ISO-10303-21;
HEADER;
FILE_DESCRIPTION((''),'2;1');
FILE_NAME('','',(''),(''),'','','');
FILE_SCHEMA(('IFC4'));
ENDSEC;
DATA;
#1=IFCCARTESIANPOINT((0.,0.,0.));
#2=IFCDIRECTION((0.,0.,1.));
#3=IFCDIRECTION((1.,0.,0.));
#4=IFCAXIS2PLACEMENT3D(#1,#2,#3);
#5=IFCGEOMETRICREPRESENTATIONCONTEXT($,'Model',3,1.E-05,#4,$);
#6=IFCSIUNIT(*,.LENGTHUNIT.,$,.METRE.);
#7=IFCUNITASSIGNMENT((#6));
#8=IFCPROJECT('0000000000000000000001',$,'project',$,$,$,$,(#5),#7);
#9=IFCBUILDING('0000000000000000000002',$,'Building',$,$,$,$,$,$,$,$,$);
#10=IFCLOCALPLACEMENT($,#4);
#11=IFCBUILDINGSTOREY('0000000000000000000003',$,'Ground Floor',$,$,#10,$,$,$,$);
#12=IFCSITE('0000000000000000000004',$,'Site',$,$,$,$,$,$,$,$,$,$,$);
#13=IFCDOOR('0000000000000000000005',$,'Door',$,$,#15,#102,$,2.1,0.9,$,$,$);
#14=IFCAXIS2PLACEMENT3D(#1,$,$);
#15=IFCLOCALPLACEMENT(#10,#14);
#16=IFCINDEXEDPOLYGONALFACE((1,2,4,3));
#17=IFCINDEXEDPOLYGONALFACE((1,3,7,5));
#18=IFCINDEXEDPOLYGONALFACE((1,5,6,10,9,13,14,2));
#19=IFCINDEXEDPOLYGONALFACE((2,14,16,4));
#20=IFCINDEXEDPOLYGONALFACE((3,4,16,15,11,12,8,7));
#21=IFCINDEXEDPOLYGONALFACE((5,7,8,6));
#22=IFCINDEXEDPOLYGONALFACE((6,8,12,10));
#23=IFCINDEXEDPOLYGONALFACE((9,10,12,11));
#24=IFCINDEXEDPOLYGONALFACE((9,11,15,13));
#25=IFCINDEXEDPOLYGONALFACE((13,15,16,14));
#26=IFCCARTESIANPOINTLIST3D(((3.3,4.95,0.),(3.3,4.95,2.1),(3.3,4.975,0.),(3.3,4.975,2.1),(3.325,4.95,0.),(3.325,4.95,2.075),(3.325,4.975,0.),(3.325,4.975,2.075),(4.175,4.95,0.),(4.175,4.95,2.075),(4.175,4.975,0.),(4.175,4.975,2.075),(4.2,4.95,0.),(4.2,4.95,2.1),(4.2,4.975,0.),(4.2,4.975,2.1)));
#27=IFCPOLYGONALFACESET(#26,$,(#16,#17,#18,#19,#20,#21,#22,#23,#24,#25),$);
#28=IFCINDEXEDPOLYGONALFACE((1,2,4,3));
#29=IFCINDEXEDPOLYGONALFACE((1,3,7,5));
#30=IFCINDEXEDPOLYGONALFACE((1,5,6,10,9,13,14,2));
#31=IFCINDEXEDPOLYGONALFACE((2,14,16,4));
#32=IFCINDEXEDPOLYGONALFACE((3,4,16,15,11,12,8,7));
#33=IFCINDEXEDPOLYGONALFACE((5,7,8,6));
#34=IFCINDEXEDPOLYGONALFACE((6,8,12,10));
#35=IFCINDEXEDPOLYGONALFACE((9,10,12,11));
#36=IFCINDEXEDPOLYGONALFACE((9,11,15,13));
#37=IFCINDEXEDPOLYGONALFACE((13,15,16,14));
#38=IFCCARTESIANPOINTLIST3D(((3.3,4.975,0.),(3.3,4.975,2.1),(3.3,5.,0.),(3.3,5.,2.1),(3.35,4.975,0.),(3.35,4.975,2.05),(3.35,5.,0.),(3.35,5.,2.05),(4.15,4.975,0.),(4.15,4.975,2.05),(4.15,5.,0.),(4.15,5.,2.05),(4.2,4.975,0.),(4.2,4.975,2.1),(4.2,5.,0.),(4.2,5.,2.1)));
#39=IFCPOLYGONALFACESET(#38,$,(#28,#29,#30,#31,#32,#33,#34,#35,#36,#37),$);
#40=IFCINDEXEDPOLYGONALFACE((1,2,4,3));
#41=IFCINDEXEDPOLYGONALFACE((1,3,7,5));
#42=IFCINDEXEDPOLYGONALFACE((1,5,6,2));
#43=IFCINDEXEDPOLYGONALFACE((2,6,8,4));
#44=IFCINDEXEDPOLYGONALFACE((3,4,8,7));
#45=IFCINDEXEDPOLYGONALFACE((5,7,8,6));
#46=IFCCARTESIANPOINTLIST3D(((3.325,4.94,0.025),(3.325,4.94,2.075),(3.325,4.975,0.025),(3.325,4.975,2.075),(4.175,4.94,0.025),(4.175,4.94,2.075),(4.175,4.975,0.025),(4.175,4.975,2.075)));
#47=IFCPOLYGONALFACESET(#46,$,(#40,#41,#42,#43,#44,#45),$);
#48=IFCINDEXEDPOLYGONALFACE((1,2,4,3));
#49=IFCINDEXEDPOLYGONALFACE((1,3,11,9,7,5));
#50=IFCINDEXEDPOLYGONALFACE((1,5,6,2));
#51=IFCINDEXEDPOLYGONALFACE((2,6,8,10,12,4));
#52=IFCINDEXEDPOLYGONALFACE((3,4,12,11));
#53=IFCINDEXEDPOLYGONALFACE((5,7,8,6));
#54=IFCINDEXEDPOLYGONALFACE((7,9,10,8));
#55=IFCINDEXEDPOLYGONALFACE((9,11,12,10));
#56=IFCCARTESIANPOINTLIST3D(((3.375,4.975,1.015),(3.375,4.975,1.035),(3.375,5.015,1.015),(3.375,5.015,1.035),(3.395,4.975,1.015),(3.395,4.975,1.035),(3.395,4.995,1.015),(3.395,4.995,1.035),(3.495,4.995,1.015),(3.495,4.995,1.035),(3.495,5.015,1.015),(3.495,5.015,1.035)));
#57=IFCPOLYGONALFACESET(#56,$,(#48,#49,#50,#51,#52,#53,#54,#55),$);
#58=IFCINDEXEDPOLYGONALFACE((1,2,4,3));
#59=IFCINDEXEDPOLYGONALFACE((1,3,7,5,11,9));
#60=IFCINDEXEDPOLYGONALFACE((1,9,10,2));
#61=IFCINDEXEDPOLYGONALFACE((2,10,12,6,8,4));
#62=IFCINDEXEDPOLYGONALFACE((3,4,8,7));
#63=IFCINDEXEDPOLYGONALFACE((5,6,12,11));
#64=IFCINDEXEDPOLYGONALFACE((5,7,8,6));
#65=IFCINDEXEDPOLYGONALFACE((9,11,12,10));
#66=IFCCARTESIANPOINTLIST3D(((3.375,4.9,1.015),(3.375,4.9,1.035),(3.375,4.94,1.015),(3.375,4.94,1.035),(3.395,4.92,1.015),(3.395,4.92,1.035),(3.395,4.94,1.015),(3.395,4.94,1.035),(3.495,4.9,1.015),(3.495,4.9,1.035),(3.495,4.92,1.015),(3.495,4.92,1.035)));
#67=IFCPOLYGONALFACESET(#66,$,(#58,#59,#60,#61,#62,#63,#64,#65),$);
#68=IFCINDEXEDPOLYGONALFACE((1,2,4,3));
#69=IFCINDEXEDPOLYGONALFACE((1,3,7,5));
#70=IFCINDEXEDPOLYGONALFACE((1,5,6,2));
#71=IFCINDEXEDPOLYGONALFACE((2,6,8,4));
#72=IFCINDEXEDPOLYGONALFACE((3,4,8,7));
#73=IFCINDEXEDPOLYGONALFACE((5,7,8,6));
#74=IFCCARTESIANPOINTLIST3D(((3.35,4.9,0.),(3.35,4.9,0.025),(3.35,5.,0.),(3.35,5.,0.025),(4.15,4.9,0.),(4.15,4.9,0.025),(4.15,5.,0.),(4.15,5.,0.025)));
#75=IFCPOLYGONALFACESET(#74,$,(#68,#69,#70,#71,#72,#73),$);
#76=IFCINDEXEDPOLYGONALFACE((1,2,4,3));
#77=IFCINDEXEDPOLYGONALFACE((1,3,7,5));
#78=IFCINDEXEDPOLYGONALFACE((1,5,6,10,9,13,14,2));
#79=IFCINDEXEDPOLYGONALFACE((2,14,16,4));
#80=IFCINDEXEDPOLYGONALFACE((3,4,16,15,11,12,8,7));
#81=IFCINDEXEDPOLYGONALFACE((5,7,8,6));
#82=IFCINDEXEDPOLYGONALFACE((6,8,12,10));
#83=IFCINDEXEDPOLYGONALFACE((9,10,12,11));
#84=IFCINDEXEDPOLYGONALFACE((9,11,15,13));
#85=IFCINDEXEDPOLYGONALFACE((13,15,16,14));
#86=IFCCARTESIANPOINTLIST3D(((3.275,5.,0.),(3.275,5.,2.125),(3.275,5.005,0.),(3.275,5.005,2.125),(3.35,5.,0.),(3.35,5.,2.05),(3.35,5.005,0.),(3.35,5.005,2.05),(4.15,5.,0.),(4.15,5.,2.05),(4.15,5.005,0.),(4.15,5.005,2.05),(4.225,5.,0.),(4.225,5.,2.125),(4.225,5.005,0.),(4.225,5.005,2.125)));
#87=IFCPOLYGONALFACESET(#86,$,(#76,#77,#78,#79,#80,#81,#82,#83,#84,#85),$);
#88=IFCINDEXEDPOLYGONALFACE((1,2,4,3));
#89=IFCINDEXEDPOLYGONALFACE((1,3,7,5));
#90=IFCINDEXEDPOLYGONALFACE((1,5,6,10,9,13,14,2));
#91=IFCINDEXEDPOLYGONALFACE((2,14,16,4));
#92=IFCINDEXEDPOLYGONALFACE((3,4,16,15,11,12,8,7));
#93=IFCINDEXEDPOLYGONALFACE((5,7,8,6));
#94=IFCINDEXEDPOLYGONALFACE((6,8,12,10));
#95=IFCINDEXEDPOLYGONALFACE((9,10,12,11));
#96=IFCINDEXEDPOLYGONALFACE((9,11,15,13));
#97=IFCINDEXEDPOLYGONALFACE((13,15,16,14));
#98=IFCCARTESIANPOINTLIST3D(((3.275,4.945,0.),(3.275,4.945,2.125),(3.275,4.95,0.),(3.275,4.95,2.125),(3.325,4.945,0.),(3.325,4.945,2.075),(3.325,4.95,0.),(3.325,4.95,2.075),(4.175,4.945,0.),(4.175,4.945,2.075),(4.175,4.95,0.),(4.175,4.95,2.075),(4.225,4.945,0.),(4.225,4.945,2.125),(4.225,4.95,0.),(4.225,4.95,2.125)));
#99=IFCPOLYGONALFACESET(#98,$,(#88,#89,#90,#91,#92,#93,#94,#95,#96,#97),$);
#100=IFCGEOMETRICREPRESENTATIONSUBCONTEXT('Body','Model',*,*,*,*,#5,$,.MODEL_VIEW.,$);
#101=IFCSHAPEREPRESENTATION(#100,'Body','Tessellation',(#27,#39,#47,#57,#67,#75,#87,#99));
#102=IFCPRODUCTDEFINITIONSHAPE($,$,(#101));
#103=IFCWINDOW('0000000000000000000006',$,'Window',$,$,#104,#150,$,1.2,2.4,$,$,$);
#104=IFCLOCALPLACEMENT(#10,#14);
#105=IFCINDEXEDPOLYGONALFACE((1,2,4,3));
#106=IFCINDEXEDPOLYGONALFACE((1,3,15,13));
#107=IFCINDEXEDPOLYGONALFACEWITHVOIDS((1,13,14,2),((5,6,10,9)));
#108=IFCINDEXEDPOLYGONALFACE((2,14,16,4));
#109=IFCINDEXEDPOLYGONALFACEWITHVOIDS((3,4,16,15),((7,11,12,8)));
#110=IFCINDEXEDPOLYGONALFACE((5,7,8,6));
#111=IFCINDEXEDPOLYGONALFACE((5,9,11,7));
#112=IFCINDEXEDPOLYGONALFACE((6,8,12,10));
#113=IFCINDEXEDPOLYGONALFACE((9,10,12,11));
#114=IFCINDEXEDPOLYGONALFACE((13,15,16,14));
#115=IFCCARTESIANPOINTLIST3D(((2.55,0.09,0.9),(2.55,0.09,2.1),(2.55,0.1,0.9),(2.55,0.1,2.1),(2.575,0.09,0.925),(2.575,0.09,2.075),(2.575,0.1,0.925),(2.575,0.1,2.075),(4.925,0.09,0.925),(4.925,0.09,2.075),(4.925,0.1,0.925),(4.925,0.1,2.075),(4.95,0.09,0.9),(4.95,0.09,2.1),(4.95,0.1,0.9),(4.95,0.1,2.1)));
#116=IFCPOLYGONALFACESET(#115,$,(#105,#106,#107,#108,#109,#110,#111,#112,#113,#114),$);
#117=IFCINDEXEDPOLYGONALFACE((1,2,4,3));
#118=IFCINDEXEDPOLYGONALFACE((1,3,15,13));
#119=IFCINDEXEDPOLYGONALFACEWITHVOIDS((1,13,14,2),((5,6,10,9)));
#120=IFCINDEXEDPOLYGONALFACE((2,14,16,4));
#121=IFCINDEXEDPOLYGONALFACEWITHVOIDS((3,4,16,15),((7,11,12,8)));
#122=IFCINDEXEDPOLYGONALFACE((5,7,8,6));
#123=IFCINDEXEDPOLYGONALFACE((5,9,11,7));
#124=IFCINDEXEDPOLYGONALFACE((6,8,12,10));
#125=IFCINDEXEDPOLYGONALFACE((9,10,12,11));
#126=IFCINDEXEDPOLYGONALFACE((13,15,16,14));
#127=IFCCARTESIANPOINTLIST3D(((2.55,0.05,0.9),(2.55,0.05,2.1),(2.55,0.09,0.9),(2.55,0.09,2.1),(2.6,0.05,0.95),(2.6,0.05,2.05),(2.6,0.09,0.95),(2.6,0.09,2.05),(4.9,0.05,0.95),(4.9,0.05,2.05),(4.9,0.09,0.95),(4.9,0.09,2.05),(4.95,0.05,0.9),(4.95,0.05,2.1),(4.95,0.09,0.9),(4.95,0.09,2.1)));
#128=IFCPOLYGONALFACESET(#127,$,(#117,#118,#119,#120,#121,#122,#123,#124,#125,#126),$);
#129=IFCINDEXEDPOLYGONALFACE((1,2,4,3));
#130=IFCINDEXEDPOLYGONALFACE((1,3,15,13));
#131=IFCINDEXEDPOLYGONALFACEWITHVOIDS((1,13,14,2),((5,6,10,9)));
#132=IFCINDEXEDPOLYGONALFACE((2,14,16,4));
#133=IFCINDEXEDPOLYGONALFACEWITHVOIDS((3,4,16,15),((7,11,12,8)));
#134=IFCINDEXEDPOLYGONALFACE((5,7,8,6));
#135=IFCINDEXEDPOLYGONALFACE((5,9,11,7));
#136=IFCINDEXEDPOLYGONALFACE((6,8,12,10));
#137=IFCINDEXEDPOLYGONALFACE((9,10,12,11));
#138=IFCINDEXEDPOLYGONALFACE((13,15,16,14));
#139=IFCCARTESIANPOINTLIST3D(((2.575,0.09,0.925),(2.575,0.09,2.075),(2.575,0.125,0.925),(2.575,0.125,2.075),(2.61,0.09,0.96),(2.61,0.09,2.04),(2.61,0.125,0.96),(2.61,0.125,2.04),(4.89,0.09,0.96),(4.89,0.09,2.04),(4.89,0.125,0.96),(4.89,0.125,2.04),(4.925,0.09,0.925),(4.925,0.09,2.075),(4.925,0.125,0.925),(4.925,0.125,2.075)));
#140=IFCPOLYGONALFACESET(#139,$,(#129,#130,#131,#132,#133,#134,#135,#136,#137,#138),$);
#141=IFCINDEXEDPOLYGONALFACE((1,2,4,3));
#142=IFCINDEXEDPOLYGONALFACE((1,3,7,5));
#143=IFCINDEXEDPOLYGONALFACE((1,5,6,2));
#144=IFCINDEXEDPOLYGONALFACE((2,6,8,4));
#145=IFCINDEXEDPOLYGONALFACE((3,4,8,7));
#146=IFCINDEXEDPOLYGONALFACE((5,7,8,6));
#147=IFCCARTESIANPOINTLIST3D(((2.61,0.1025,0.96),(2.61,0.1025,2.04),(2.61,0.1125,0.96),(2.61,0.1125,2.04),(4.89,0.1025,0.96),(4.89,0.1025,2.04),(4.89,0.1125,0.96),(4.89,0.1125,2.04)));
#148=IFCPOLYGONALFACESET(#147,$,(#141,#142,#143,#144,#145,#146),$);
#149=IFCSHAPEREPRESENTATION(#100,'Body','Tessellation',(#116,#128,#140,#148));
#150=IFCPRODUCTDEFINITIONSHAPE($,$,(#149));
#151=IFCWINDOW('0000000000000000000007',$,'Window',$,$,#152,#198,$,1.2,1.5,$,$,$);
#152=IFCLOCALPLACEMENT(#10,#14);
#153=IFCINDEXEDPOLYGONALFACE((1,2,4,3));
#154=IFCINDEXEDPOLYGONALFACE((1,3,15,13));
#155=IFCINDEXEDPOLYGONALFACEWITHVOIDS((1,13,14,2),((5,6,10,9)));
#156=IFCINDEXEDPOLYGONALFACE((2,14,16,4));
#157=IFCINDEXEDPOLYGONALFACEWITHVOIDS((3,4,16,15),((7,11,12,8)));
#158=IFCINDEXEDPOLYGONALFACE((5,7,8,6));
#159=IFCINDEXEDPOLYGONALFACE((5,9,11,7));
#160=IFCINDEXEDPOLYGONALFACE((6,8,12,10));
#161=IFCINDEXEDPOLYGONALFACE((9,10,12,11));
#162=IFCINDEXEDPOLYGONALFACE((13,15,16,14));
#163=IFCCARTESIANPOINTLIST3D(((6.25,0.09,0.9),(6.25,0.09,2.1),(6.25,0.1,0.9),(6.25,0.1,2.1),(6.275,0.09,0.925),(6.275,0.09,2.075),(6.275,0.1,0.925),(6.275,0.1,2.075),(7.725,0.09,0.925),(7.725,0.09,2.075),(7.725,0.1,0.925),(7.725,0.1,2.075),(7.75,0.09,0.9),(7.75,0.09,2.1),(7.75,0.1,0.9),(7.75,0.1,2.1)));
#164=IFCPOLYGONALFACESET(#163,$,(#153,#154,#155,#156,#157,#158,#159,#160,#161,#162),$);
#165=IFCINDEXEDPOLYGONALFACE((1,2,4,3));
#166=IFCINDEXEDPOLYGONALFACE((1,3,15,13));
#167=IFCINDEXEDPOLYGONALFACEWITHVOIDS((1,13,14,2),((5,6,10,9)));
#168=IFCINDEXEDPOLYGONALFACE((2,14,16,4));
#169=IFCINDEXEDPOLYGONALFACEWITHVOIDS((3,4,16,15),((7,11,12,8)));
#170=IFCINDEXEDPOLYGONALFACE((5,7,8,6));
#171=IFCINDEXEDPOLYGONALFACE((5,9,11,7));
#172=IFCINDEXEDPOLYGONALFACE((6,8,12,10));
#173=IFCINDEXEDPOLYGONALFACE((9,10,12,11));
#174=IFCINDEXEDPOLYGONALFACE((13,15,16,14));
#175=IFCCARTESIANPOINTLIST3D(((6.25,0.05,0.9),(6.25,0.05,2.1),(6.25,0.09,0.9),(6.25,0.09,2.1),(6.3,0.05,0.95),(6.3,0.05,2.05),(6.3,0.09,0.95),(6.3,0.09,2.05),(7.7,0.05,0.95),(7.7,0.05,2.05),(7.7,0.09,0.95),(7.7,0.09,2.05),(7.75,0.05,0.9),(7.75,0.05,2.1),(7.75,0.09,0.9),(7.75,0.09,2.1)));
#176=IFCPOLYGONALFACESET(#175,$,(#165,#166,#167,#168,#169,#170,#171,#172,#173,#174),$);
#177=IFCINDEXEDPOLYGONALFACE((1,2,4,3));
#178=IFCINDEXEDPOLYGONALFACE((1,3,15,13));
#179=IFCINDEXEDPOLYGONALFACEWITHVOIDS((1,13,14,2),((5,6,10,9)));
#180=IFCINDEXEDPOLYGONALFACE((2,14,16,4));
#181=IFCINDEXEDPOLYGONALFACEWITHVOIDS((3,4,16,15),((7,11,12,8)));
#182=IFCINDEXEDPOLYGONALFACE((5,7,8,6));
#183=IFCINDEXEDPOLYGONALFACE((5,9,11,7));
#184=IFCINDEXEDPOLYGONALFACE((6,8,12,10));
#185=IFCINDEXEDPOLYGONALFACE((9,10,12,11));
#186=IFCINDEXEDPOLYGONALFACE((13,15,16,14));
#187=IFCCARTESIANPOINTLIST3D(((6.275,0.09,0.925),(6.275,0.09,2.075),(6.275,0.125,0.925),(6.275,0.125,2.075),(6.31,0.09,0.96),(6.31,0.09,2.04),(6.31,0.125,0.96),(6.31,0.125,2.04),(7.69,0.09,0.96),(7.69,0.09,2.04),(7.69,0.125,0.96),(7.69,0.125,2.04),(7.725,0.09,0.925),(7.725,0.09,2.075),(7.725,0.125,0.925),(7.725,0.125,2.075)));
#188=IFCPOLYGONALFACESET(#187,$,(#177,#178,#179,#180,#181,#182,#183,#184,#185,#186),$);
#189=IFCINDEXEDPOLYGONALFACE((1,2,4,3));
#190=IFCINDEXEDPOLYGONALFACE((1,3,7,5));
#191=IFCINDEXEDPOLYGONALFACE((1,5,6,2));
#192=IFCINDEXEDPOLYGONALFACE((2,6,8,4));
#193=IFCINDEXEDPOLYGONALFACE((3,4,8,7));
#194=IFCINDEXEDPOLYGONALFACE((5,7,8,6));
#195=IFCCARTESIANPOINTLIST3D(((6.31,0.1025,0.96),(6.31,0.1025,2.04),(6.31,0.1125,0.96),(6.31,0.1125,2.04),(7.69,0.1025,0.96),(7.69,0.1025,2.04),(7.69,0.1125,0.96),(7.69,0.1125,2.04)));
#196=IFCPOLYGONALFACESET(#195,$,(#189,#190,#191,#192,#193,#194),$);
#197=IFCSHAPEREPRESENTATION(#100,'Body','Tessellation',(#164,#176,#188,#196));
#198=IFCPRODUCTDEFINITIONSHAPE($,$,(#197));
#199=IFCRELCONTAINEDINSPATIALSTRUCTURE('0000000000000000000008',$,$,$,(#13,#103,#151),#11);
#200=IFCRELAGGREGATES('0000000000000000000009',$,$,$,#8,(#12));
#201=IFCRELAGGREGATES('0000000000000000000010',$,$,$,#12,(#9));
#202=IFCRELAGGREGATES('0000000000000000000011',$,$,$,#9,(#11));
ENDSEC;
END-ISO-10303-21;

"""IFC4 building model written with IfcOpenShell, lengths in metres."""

from ifc_helpers import new_model, si_unit, frame, origin_with_axes, place, context, subcontext, project, spatial, line, indexed_curve, outline, extrude, element, save


model = new_model("IFC4")

# Units and contexts
model_context = context("Model", 3, precision=1e-05, world=origin_with_axes())
body_context = subcontext(model_context, "Body", "Model", "MODEL_VIEW")
ifc_project = project(units=[si_unit("LENGTHUNIT", "METRE")], contexts=[model_context])

# Site, building, storey
site = spatial("IfcSite", under=ifc_project, Name="Site")
building = spatial("IfcBuilding", under=site, Name="Building")
storey_placement = place(None, origin_with_axes())
storey = spatial("IfcBuildingStorey", under=building, at=storey_placement, Name="Ground Floor")

# Door
door_1_placement = place(storey_placement, frame((4.2, 5.0, 0.0), z_axis=(0.0, 0.0, 1.0), x_axis=(-1.0, 0.0, 0.0)))
element("IfcDoor", 1, at=door_1_placement, inside=storey, Name="Door", OverallHeight=2.1, OverallWidth=0.9, context=body_context, shape_type="SweptSolid", body=[
    extrude(outline(indexed_curve([(0.0, 0.0), (0.0, 2.1), (0.9, 2.1), (0.9, 0.0), (0.875, 0.0), (0.875, 2.075), (0.025, 2.075), (0.025, 0.0)], segments=[line(1, 2, 3, 4, 5, 6, 7, 8, 1)])), frame((0.0, 0.025, 0.0), z_axis=(0.0, -1.0, 0.0), x_axis=(1.0, 0.0, 0.0)), (0.0, 0.0, -1.0), 0.025),
    extrude(outline(indexed_curve([(0.0, 0.0), (0.0, 2.1), (0.9, 2.1), (0.9, 0.0), (0.85, 0.0), (0.85, 2.05), (0.05, 2.05), (0.05, 0.0)], segments=[line(1, 2, 3, 4, 5, 6, 7, 8, 1)])), frame((0.0, 0.0, 0.0), z_axis=(0.0, -1.0, 0.0), x_axis=(1.0, 0.0, 0.0)), (0.0, 0.0, -1.0), 0.025),
    extrude(outline(indexed_curve([(0.0, 0.0), (0.85, 0.0), (0.85, 0.035), (0.0, 0.035)], segments=[line(1, 2, 3, 4, 1)])), frame((0.025, 0.025, 0.025), z_axis=(0.0, 0.0, 1.0), x_axis=(1.0, 0.0, 0.0)), (0.0, 0.0, 1.0), 2.05),
    extrude(outline(indexed_curve([(0.0, 0.0), (0.0, -0.04), (-0.12, -0.04), (-0.12, -0.02), (-0.02, -0.02), (-0.02, 0.0)], segments=[line(1, 2, 3, 4, 5, 6, 1)])), frame((0.825, 0.025, 1.015), z_axis=(0.0, 0.0, 1.0), x_axis=(1.0, 0.0, 0.0)), (0.0, 0.0, 1.0), 0.02),
    extrude(outline(indexed_curve([(0.0, 0.0), (0.0, 0.04), (-0.12, 0.04), (-0.12, 0.02), (-0.02, 0.02), (-0.02, 0.0)], segments=[line(1, 2, 3, 4, 5, 6, 1)])), frame((0.825, 0.06, 1.015), z_axis=(0.0, 0.0, 1.0), x_axis=(1.0, 0.0, 0.0)), (0.0, 0.0, 1.0), 0.02),
    extrude(outline(indexed_curve([(0.0, 0.0), (0.8, 0.0), (0.8, 0.1), (0.0, 0.1)], segments=[line(1, 2, 3, 4, 1)])), frame((0.05, 0.0, 0.0), z_axis=(0.0, 0.0, 1.0), x_axis=(1.0, 0.0, 0.0)), (0.0, 0.0, 1.0), 0.025),
    extrude(outline(indexed_curve([(0.0, 0.0), (0.0, 2.125), (0.95, 2.125), (0.95, 0.0), (0.875, 0.0), (0.875, 2.05), (0.075, 2.05), (0.075, 0.0)], segments=[line(1, 2, 3, 4, 5, 6, 7, 8, 1)])), frame((-0.025, -0.005, 0.0), z_axis=(0.0, -1.0, 0.0), x_axis=(1.0, 0.0, 0.0)), (0.0, 0.0, -1.0), 0.005),
    extrude(outline(indexed_curve([(0.0, 0.0), (0.0, 2.125), (0.95, 2.125), (0.95, 0.0), (0.9, 0.0), (0.9, 2.075), (0.05, 2.075), (0.05, 0.0)], segments=[line(1, 2, 3, 4, 5, 6, 7, 8, 1)])), frame((-0.025, 0.05, 0.0), z_axis=(0.0, -1.0, 0.0), x_axis=(1.0, 0.0, 0.0)), (0.0, 0.0, -1.0), 0.005),
])

# Windows
window_1_placement = place(storey_placement, frame((2.55, 0.0, 0.9), z_axis=(0.0, 0.0, 1.0), x_axis=(1.0, 0.0, 0.0)))
element("IfcWindow", 2, at=window_1_placement, inside=storey, Name="Window", OverallHeight=1.2, OverallWidth=2.4, context=body_context, shape_type="SweptSolid", body=[
    extrude(outline(indexed_curve([(0.0, 0.0), (2.4, 0.0), (2.4, 1.2), (0.0, 1.2)], segments=[line(1, 2, 3, 4, 1)]), holes=[indexed_curve([(0.025, 0.025), (2.375, 0.025), (2.375, 1.175), (0.025, 1.175)], segments=[line(1, 2, 3, 4, 1)])]), frame((0.0, 0.09, 0.0), z_axis=(0.0, -1.0, 0.0), x_axis=(1.0, 0.0, 0.0)), (0.0, 0.0, -1.0), 0.01),
    extrude(outline(indexed_curve([(0.0, 0.0), (2.4, 0.0), (2.4, 1.2), (0.0, 1.2)], segments=[line(1, 2, 3, 4, 1)]), holes=[indexed_curve([(0.05, 0.05), (2.35, 0.05), (2.35, 1.15), (0.05, 1.15)], segments=[line(1, 2, 3, 4, 1)])]), frame((0.0, 0.05, 0.0), z_axis=(0.0, -1.0, 0.0), x_axis=(1.0, 0.0, 0.0)), (0.0, 0.0, -1.0), 0.04),
    extrude(outline(indexed_curve([(0.0, 0.0), (2.35, 0.0), (2.35, 1.15), (0.0, 1.15)], segments=[line(1, 2, 3, 4, 1)]), holes=[indexed_curve([(0.035, 0.035), (2.315, 0.035), (2.315, 1.115), (0.035, 1.115)], segments=[line(1, 2, 3, 4, 1)])]), frame((0.025, 0.09, 0.025), z_axis=(0.0, -1.0, 0.0), x_axis=(1.0, 0.0, 0.0)), (0.0, 0.0, -1.0), 0.035),
    extrude(outline(indexed_curve([(0.035, 0.035), (2.315, 0.035), (2.315, 1.115), (0.035, 1.115)], segments=[line(1, 2, 3, 4, 1)])), frame((0.025, 0.1025, 0.025), z_axis=(0.0, -1.0, 0.0), x_axis=(1.0, 0.0, 0.0)), (0.0, 0.0, -1.0), 0.01),
])
window_2_placement = place(storey_placement, frame((6.25, 0.0, 0.9), z_axis=(0.0, 0.0, 1.0), x_axis=(1.0, 0.0, 0.0)))
element("IfcWindow", 3, at=window_2_placement, inside=storey, Name="Window", OverallHeight=1.2, OverallWidth=1.5, context=body_context, shape_type="SweptSolid", body=[
    extrude(outline(indexed_curve([(0.0, 0.0), (1.5, 0.0), (1.5, 1.2), (0.0, 1.2)], segments=[line(1, 2, 3, 4, 1)]), holes=[indexed_curve([(0.025, 0.025), (1.475, 0.025), (1.475, 1.175), (0.025, 1.175)], segments=[line(1, 2, 3, 4, 1)])]), frame((0.0, 0.09, 0.0), z_axis=(0.0, -1.0, 0.0), x_axis=(1.0, 0.0, 0.0)), (0.0, 0.0, -1.0), 0.01),
    extrude(outline(indexed_curve([(0.0, 0.0), (1.5, 0.0), (1.5, 1.2), (0.0, 1.2)], segments=[line(1, 2, 3, 4, 1)]), holes=[indexed_curve([(0.05, 0.05), (1.45, 0.05), (1.45, 1.15), (0.05, 1.15)], segments=[line(1, 2, 3, 4, 1)])]), frame((0.0, 0.05, 0.0), z_axis=(0.0, -1.0, 0.0), x_axis=(1.0, 0.0, 0.0)), (0.0, 0.0, -1.0), 0.04),
    extrude(outline(indexed_curve([(0.0, 0.0), (1.45, 0.0), (1.45, 1.15), (0.0, 1.15)], segments=[line(1, 2, 3, 4, 1)]), holes=[indexed_curve([(0.035, 0.035), (1.415, 0.035), (1.415, 1.115), (0.035, 1.115)], segments=[line(1, 2, 3, 4, 1)])]), frame((0.025, 0.09, 0.025), z_axis=(0.0, -1.0, 0.0), x_axis=(1.0, 0.0, 0.0)), (0.0, 0.0, -1.0), 0.035),
    extrude(outline(indexed_curve([(0.035, 0.035), (1.415, 0.035), (1.415, 1.115), (0.035, 1.115)], segments=[line(1, 2, 3, 4, 1)])), frame((0.025, 0.1025, 0.025), z_axis=(0.0, -1.0, 0.0), x_axis=(1.0, 0.0, 0.0)), (0.0, 0.0, -1.0), 0.01),
])

save(model, "model.ifc")
